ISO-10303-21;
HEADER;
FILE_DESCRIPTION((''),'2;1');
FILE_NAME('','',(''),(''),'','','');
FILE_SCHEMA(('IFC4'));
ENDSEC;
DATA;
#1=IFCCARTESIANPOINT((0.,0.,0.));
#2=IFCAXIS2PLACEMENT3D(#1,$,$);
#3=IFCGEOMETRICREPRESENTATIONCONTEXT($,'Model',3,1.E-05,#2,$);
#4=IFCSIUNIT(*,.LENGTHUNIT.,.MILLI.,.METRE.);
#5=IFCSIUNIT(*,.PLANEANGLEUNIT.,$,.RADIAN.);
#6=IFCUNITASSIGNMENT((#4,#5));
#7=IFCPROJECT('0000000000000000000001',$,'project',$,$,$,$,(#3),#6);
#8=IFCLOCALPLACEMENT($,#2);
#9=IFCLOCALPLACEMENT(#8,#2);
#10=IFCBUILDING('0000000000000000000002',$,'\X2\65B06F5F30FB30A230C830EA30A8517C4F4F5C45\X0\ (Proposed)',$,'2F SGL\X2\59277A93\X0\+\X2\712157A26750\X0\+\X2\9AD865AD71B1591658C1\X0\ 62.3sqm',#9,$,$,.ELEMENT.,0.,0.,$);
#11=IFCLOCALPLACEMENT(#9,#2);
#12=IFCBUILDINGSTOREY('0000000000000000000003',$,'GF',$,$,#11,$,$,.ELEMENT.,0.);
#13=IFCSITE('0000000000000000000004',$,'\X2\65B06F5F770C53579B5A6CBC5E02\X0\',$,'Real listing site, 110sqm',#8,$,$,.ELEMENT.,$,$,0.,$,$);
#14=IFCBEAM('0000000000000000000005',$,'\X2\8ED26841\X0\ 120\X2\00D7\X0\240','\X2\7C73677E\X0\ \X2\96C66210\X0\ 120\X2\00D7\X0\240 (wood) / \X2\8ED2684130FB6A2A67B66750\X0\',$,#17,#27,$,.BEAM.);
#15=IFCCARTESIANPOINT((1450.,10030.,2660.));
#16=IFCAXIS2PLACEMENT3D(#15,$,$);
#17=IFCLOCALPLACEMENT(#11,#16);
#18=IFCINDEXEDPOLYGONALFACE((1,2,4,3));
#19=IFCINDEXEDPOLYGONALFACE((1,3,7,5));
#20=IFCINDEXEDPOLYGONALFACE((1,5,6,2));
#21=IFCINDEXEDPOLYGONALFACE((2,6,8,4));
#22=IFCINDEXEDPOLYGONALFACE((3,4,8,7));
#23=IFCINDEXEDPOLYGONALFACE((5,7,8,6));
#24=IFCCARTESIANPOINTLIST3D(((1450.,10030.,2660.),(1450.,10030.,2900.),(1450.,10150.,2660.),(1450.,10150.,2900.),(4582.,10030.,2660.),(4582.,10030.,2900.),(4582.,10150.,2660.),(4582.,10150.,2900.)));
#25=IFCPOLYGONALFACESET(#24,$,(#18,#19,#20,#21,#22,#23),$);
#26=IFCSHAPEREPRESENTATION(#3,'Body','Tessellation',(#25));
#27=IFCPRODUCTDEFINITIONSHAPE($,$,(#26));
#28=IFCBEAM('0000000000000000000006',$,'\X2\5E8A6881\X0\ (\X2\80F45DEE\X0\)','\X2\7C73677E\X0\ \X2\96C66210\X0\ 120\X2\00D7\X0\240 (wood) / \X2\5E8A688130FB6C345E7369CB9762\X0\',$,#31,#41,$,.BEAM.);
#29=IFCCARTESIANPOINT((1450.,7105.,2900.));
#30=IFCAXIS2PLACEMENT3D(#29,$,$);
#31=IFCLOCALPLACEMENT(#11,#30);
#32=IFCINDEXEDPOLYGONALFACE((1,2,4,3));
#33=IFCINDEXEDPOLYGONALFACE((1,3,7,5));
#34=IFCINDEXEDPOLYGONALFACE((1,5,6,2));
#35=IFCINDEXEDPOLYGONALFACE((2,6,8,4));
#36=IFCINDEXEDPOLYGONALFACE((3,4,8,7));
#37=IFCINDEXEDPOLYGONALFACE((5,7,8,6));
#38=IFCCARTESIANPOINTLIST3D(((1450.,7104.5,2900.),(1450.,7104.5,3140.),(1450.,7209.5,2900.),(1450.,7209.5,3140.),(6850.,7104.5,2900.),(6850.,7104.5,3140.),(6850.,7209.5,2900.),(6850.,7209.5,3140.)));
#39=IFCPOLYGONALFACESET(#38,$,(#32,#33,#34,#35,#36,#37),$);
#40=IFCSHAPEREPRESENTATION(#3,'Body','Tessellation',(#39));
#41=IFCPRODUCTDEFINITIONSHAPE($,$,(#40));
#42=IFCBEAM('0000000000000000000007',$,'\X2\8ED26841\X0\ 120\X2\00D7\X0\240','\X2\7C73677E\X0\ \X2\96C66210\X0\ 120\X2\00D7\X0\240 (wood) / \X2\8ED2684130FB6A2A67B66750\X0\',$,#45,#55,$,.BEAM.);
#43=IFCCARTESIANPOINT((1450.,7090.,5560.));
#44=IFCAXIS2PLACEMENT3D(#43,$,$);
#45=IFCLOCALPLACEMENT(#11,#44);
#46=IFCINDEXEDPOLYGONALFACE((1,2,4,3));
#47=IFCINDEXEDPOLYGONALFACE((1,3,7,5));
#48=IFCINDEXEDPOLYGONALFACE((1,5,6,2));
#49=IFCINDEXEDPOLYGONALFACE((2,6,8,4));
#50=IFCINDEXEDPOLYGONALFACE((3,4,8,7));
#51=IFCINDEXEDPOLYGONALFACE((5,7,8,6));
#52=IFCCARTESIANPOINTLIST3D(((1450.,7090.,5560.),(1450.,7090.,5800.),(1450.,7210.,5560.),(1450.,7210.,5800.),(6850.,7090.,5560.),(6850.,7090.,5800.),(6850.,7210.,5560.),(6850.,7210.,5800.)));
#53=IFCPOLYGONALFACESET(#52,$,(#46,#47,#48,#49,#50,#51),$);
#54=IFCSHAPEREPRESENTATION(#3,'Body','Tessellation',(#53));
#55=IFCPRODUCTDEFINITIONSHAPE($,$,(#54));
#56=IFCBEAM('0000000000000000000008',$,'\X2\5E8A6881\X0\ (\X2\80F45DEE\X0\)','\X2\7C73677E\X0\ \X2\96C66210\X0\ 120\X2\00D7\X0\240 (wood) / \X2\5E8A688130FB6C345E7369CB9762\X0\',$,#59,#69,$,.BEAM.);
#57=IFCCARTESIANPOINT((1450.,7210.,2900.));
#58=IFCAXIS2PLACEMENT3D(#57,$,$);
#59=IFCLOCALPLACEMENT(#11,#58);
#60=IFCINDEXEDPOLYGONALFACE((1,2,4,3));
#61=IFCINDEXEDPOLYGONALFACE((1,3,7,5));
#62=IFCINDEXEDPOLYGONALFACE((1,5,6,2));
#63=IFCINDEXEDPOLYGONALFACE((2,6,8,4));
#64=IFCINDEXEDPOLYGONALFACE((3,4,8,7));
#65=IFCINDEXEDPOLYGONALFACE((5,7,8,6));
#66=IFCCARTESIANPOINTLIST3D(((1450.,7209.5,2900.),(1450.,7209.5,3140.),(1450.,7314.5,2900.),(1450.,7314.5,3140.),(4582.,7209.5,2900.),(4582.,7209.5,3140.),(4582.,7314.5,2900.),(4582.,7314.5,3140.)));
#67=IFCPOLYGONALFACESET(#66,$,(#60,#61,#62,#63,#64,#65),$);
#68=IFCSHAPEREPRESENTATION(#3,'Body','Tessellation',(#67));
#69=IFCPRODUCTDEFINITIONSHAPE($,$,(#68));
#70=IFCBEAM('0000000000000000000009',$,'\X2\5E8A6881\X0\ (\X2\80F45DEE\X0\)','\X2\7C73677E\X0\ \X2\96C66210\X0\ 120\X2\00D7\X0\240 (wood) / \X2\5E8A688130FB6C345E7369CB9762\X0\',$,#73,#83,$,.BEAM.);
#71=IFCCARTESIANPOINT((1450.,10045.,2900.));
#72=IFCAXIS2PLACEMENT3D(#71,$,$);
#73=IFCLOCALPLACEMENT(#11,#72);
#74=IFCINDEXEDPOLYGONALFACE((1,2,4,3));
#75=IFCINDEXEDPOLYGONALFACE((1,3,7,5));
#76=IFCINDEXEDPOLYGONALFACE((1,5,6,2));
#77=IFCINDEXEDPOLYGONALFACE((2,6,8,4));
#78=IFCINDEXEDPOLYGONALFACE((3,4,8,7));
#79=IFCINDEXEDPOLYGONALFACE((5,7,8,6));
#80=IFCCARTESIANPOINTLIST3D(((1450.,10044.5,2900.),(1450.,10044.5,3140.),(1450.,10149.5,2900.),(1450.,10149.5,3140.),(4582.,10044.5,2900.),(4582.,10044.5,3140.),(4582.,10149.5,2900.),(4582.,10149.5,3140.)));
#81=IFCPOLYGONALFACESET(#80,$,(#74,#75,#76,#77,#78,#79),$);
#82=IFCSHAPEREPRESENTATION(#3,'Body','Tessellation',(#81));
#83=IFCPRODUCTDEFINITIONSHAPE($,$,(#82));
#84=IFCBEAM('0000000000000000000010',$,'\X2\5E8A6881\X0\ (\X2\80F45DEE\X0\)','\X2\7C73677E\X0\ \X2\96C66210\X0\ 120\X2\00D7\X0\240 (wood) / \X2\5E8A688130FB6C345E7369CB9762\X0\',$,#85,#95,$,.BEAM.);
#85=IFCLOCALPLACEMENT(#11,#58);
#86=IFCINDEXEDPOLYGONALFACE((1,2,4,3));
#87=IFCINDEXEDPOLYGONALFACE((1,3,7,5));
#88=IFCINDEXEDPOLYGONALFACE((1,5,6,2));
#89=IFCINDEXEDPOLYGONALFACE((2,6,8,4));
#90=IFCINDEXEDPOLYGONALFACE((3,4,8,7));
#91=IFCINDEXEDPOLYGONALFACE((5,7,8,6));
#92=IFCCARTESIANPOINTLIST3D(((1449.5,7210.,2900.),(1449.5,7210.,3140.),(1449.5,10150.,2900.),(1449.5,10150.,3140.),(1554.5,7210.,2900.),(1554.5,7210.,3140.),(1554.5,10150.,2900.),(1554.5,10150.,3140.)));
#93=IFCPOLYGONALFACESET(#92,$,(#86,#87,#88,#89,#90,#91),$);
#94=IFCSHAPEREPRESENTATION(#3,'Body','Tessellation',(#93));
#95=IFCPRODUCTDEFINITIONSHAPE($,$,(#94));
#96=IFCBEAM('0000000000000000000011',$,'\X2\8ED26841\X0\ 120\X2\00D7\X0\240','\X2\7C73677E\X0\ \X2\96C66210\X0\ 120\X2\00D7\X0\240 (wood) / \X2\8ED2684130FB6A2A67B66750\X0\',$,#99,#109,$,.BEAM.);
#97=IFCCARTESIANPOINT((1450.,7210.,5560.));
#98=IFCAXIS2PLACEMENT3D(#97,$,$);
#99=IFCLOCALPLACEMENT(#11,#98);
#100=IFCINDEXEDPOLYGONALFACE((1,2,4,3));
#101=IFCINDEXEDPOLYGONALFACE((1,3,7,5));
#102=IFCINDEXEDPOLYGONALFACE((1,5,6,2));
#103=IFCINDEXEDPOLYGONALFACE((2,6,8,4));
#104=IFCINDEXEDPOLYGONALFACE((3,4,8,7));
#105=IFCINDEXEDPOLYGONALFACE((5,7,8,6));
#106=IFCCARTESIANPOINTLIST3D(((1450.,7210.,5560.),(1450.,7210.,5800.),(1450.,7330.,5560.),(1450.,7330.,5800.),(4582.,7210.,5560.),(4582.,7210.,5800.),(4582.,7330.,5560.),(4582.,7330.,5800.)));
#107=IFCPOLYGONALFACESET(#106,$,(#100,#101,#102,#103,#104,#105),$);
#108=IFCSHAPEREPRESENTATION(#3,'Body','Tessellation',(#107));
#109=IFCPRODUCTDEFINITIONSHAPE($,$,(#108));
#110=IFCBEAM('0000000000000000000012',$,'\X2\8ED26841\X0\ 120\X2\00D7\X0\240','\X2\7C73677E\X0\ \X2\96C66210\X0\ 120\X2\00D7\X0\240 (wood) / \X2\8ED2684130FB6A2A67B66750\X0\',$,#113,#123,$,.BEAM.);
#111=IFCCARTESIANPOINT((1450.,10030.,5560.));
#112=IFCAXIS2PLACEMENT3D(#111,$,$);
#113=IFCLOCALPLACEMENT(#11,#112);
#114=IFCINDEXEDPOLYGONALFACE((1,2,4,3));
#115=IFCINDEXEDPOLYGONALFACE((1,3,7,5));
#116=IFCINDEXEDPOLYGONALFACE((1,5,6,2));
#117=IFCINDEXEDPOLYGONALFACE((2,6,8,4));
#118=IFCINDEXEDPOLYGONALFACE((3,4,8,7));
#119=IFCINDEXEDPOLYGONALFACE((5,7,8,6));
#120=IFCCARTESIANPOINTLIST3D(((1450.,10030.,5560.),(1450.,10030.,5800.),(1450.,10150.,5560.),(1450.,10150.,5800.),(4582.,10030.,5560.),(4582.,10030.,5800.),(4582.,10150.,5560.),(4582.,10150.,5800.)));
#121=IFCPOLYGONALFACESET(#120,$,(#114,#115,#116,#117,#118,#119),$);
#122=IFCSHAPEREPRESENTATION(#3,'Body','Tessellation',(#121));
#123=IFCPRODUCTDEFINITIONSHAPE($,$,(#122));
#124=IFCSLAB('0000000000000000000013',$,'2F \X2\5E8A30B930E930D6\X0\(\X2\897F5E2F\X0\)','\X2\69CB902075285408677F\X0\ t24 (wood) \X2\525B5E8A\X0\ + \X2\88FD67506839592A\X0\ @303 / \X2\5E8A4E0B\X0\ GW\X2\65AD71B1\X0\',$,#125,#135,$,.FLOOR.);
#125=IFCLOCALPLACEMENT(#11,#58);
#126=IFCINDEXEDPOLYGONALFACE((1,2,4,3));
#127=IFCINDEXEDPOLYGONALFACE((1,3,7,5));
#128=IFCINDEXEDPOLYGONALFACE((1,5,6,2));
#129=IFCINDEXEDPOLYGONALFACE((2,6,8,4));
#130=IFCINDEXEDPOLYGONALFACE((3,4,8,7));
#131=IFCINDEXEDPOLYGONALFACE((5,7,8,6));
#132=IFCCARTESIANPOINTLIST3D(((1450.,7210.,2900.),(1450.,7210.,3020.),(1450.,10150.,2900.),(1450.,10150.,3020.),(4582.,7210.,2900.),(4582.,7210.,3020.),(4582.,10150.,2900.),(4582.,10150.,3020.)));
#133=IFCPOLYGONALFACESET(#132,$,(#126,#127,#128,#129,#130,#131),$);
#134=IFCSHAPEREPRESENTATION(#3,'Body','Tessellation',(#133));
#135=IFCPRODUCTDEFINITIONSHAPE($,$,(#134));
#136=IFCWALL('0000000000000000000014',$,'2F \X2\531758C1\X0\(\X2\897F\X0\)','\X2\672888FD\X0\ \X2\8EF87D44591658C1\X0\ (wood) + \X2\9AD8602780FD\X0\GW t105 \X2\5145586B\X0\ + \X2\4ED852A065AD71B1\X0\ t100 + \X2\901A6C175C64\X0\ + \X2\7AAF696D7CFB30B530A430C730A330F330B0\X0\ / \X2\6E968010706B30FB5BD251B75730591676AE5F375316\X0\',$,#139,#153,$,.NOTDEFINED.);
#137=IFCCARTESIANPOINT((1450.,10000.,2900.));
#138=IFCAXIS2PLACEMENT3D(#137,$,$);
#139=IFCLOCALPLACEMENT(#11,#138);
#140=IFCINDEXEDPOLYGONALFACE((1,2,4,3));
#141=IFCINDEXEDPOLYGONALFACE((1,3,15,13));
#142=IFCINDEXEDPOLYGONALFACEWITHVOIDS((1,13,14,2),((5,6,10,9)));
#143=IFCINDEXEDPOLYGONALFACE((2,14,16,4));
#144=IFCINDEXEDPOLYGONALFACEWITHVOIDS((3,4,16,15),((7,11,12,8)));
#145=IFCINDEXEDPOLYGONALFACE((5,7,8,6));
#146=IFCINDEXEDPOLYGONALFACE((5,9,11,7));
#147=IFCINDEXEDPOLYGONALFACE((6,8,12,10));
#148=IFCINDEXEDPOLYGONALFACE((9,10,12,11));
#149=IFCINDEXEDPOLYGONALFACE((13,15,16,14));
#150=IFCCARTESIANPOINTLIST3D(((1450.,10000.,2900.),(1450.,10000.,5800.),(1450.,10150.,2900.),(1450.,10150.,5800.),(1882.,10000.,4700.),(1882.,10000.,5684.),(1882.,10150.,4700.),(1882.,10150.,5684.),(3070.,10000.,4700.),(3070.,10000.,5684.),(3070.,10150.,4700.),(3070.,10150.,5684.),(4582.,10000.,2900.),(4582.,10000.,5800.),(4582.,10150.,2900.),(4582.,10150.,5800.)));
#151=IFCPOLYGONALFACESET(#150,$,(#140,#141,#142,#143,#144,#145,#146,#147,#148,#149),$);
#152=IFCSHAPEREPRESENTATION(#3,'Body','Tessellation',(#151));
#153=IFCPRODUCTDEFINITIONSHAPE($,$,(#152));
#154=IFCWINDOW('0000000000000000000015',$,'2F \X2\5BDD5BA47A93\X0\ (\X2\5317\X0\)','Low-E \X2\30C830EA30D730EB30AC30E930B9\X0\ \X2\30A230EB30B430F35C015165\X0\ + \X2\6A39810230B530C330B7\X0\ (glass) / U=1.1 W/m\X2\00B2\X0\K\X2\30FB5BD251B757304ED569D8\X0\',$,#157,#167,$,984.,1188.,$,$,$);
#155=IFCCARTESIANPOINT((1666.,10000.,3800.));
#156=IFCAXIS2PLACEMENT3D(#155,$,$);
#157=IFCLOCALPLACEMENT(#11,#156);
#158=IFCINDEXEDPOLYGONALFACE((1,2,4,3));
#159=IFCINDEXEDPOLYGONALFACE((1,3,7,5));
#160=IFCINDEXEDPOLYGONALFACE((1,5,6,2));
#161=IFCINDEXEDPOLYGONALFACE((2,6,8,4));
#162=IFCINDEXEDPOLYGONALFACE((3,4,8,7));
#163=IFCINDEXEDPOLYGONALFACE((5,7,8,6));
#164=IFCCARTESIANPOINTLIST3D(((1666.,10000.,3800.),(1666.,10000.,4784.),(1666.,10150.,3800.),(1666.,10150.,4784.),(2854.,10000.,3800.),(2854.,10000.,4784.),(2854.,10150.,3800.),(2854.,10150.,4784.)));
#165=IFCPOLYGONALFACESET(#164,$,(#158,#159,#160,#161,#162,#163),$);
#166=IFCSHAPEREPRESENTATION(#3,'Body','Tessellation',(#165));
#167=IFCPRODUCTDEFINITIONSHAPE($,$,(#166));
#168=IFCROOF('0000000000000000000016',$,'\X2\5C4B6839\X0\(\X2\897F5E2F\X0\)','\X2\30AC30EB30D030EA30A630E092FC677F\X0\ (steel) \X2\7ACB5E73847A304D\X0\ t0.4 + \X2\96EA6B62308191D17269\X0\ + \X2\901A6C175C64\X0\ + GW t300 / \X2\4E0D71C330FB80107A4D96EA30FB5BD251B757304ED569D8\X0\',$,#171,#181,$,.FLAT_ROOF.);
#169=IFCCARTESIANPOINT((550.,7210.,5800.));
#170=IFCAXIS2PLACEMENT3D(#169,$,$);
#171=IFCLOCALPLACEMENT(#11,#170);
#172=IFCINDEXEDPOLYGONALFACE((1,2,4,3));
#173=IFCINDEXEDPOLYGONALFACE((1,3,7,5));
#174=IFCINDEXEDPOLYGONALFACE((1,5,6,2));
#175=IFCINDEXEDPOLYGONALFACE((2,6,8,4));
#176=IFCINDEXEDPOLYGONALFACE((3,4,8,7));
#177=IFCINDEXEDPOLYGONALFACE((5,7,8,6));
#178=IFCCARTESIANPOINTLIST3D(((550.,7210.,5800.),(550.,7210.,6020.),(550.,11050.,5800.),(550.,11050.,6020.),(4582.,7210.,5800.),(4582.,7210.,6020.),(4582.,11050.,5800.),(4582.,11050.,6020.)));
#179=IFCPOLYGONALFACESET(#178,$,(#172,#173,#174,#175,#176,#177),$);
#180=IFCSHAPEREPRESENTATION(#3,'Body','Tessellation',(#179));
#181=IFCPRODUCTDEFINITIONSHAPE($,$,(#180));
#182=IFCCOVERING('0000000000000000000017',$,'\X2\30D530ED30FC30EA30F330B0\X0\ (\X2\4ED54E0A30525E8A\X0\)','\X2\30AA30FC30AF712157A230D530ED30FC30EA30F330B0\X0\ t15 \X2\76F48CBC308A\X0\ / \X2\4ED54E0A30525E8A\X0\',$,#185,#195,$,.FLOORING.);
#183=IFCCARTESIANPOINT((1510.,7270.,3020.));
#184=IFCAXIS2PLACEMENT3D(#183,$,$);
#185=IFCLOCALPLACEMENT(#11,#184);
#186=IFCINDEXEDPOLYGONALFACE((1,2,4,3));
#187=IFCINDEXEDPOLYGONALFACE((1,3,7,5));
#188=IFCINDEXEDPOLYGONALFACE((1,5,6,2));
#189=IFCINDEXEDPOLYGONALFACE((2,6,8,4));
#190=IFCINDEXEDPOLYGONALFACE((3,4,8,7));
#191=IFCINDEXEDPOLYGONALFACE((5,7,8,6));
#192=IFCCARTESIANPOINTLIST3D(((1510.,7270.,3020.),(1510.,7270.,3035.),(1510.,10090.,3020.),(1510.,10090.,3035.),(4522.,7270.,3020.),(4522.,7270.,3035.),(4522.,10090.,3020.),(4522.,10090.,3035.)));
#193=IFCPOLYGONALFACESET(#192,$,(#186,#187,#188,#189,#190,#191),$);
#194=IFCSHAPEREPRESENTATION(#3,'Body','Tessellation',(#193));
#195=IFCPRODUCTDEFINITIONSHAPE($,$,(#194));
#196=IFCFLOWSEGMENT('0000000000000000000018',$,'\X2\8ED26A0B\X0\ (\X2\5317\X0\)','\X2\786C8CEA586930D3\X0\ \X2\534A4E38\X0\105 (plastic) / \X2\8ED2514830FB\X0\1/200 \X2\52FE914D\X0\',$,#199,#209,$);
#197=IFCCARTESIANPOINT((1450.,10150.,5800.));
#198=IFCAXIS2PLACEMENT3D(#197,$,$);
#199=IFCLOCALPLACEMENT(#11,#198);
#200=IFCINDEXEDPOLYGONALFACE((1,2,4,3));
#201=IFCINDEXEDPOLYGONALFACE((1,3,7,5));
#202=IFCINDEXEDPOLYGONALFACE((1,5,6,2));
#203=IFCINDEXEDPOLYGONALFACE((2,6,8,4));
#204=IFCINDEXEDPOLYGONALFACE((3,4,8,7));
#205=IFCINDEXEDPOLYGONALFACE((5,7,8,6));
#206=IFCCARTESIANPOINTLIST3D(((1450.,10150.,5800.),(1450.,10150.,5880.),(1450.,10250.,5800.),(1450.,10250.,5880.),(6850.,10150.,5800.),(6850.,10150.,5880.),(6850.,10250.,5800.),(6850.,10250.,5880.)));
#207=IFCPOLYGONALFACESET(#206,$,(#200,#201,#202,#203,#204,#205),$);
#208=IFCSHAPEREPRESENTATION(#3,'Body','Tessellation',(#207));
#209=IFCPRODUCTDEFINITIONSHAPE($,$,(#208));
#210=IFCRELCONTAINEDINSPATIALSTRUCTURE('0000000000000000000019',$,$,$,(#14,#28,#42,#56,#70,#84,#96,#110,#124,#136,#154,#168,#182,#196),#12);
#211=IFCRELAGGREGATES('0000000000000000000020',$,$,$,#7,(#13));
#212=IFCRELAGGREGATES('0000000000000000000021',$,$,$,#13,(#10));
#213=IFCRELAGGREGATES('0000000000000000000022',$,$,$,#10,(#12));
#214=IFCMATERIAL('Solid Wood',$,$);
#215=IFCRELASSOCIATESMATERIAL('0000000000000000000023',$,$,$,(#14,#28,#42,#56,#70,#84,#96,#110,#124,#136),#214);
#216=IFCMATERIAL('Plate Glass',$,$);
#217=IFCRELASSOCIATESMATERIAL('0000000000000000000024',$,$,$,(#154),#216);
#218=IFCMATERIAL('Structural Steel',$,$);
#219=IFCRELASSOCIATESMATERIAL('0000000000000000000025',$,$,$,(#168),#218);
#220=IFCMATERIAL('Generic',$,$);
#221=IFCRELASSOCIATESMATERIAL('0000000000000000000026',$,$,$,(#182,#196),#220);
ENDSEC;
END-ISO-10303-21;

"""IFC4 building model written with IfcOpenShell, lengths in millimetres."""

from ifc_helpers import new_model, si_unit, frame, frame_2d, origin, place, context, project, spatial, rectangle, extrude, material, element, fill, save


model = new_model("IFC4")

# Units and contexts
model_context = context("Model", 3, precision=1e-05, world=origin())
ifc_project = project(units=[si_unit("LENGTHUNIT", "METRE", prefix="MILLI"), si_unit("PLANEANGLEUNIT", "RADIAN")], contexts=[model_context])

# Site, building, storey
site_placement = place(None, origin())
site = spatial("IfcSite", under=ifc_project, at=site_placement, Name="新潟県南魚沼市", ObjectType="Real listing site, 110sqm", CompositionType="ELEMENT", RefElevation=0.0)
building_placement = place(site_placement, origin())
building = spatial("IfcBuilding", under=site, at=building_placement, Name="新潟・アトリエ兼住居 (Proposed)", ObjectType="2F SGL大窓+無垢材+高断熱外壁 62.3sqm", CompositionType="ELEMENT", ElevationOfRefHeight=0.0, ElevationOfTerrain=0.0)
storey_placement = place(building_placement, origin())
storey = spatial("IfcBuildingStorey", under=building, at=storey_placement, Name="GF", CompositionType="ELEMENT", Elevation=0.0)

# Shared definitions
ifc_material_1 = material(Name="Solid Wood")

# Beams
beam_1_placement = place(storey_placement, frame((1450.0, 10030.0, 2660.0)))
element("IfcBeam", 1, at=beam_1_placement, inside=storey, material=ifc_material_1, Name="軒桁 120×240", Description="米松 集成 120×240 (wood) / 軒桁・横架材", PredefinedType="BEAM", context=model_context, shape_type="SweptSolid", body=[
    extrude(rectangle(XDim=3132.0, YDim=120.0, at=frame_2d((1566.0, 60.0))), frame((1450.0, 10030.0, 2660.0)), (0.0, 0.0, 1.0), 240.0),
])
beam_2_placement = place(storey_placement, frame((1450.0, 7105.0, 2900.0)))
element("IfcBeam", 2, at=beam_2_placement, inside=storey, material=ifc_material_1, Name="床梁 (胴差)", Description="米松 集成 120×240 (wood) / 床梁・水平構面", PredefinedType="BEAM", context=model_context, shape_type="SweptSolid", body=[
    extrude(rectangle(XDim=5400.0, YDim=105.0, at=frame_2d((2700.0, 52.0))), frame((1450.0, 7105.0, 2900.0)), (0.0, 0.0, 1.0), 240.0),
])
beam_3_placement = place(storey_placement, frame((1450.0, 7090.0, 5560.0)))
element("IfcBeam", 3, at=beam_3_placement, inside=storey, material=ifc_material_1, Name="軒桁 120×240", Description="米松 集成 120×240 (wood) / 軒桁・横架材", PredefinedType="BEAM", context=model_context, shape_type="SweptSolid", body=[
    extrude(rectangle(XDim=5400.0, YDim=120.0, at=frame_2d((2700.0, 60.0))), frame((1450.0, 7090.0, 5560.0)), (0.0, 0.0, 1.0), 240.0),
])
beam_4_placement = place(storey_placement, frame((1450.0, 7210.0, 2900.0)))
element("IfcBeam", 4, at=beam_4_placement, inside=storey, material=ifc_material_1, Name="床梁 (胴差)", Description="米松 集成 120×240 (wood) / 床梁・水平構面", PredefinedType="BEAM", context=model_context, shape_type="SweptSolid", body=[
    extrude(rectangle(XDim=3132.0, YDim=105.0, at=frame_2d((1566.0, 52.0))), frame((1450.0, 7210.0, 2900.0)), (0.0, 0.0, 1.0), 240.0),
])
beam_5_placement = place(storey_placement, frame((1450.0, 10045.0, 2900.0)))
element("IfcBeam", 5, at=beam_5_placement, inside=storey, material=ifc_material_1, Name="床梁 (胴差)", Description="米松 集成 120×240 (wood) / 床梁・水平構面", PredefinedType="BEAM", context=model_context, shape_type="SweptSolid", body=[
    extrude(rectangle(XDim=3132.0, YDim=105.0, at=frame_2d((1566.0, 52.0))), frame((1450.0, 10045.0, 2900.0)), (0.0, 0.0, 1.0), 240.0),
])
beam_6_placement = place(storey_placement, frame((1450.0, 7210.0, 2900.0)))
element("IfcBeam", 6, at=beam_6_placement, inside=storey, material=ifc_material_1, Name="床梁 (胴差)", Description="米松 集成 120×240 (wood) / 床梁・水平構面", PredefinedType="BEAM", context=model_context, shape_type="SweptSolid", body=[
    extrude(rectangle(XDim=105.0, YDim=2940.0, at=frame_2d((52.0, 1470.0))), frame((1450.0, 7210.0, 2900.0)), (0.0, 0.0, 1.0), 240.0),
])
beam_7_placement = place(storey_placement, frame((1450.0, 7210.0, 5560.0)))
element("IfcBeam", 7, at=beam_7_placement, inside=storey, material=ifc_material_1, Name="軒桁 120×240", Description="米松 集成 120×240 (wood) / 軒桁・横架材", PredefinedType="BEAM", context=model_context, shape_type="SweptSolid", body=[
    extrude(rectangle(XDim=3132.0, YDim=120.0, at=frame_2d((1566.0, 60.0))), frame((1450.0, 7210.0, 5560.0)), (0.0, 0.0, 1.0), 240.0),
])
beam_8_placement = place(storey_placement, frame((1450.0, 10030.0, 5560.0)))
element("IfcBeam", 8, at=beam_8_placement, inside=storey, material=ifc_material_1, Name="軒桁 120×240", Description="米松 集成 120×240 (wood) / 軒桁・横架材", PredefinedType="BEAM", context=model_context, shape_type="SweptSolid", body=[
    extrude(rectangle(XDim=3132.0, YDim=120.0, at=frame_2d((1566.0, 60.0))), frame((1450.0, 10030.0, 5560.0)), (0.0, 0.0, 1.0), 240.0),
])

# Slab
slab_placement = place(storey_placement, frame((1450.0, 7210.0, 2900.0)))
element("IfcSlab", 9, at=slab_placement, inside=storey, material=ifc_material_1, Name="2F 床スラブ(西帯)", Description="構造用合板 t24 (wood) 剛床 + 製材根太 @303 / 床下 GW断熱", PredefinedType="FLOOR", context=model_context, shape_type="SweptSolid", body=[
    extrude(rectangle(XDim=3132.0, YDim=2940.0, at=frame_2d((1566.0, 1470.0))), frame((1450.0, 7210.0, 2900.0)), (0.0, 0.0, 1.0), 120.0),
])

# Wall, opening, window
wall_1_placement = place(storey_placement, frame((1450.0, 10000.0, 2900.0)))
wall_1 = element("IfcWall", 10, at=wall_1_placement, inside=storey, material=ifc_material_1, Name="2F 北壁(西)", Description="木製 軸組外壁 (wood) + 高性能GW t105 充填 + 付加断熱 t100 + 通気層 + 窯業系サイディング / 準耐火・寒冷地外皮強化", PredefinedType="NOTDEFINED", context=model_context, shape_type="SweptSolid", body=[
    extrude(rectangle(XDim=3132.0, YDim=150.0, at=frame_2d((1566.0, 75.0))), frame((1450.0, 10000.0, 2900.0)), (0.0, 0.0, 1.0), 2900.0),
])
opening_placement = place(storey_placement, frame((1666.0, 10000.0, 3800.0)))
opening = element("IfcOpeningElement", 11, at=opening_placement, cuts=wall_1, PredefinedType="NOTDEFINED", context=model_context, shape_type="SweptSolid", body=[
    extrude(rectangle(XDim=1188.0, YDim=150.0, at=frame_2d((594.0, 75.0))), frame((1666.0, 10000.0, 3800.0)), (0.0, 0.0, 1.0), 984.0),
])
ifc_material_2 = material(Name="Plate Glass")
window_placement = place(storey_placement, frame((1666.0, 10000.0, 3800.0)))
window = element("IfcWindow", 12, at=window_placement, inside=storey, material=ifc_material_2, Name="2F 寝室窓 (北)", Description="Low-E トリプルガラス アルゴン封入 + 樹脂サッシ (glass) / U=1.1 W/m²K・寒冷地仕様", OverallHeight=984.0, OverallWidth=1188.0, context=model_context, shape_type="SweptSolid", body=[
    extrude(rectangle(XDim=1188.0, YDim=150.0, at=frame_2d((594.0, 75.0))), frame((1666.0, 10000.0, 3800.0)), (0.0, 0.0, 1.0), 984.0),
])
fill(opening, window)

# Roof
ifc_material_3 = material(Name="Structural Steel")
for number, where, name in (
    (13, (550.0, 7210.0, 5800.0), "屋根(西帯)"),
):
    element("IfcRoof", number, at=place(storey_placement, frame(where)), inside=storey, material=ifc_material_3, Name=name, Description="ガルバリウム鋼板 (steel) 立平葺き t0.4 + 雪止め金物 + 通気層 + GW t300 / 不燃・耐積雪・寒冷地仕様", PredefinedType="FLAT_ROOF", context=model_context, shape_type="SweptSolid", body=[
        extrude(rectangle(XDim=4032.0, YDim=3840.0, at=frame_2d((2016.0, 1920.0))), frame((550.0, 7210.0, 5800.0)), (0.0, 0.0, 1.0), 220.0),
    ])

# Covering
ifc_material_4 = material(Name="Generic")
covering_placement = place(storey_placement, frame((1510.0, 7270.0, 3020.0)))
element("IfcCovering", 14, at=covering_placement, inside=storey, material=ifc_material_4, Name="フローリング (仕上げ床)", Description="オーク無垢フローリング t15 直貼り / 仕上げ床", PredefinedType="FLOORING", context=model_context, shape_type="SweptSolid", body=[
    extrude(rectangle(XDim=3012.0, YDim=2820.0, at=frame_2d((1506.0, 1410.0))), frame((1510.0, 7270.0, 3020.0)), (0.0, 0.0, 1.0), 15.0),
])

# Flow segment
flow_segment_placement = place(storey_placement, frame((1450.0, 10150.0, 5800.0)))
element("IfcFlowSegment", 15, at=flow_segment_placement, inside=storey, material=ifc_material_4, Name="軒樋 (北)", Description="硬質塩ビ 半丸105 (plastic) / 軒先・1/200 勾配", context=model_context, shape_type="SweptSolid", body=[
    extrude(rectangle(XDim=5400.0, YDim=100.0, at=frame_2d((2700.0, 50.0))), frame((1450.0, 10150.0, 5800.0)), (0.0, 0.0, 1.0), 80.0),
])

save(model, "model.ifc")
